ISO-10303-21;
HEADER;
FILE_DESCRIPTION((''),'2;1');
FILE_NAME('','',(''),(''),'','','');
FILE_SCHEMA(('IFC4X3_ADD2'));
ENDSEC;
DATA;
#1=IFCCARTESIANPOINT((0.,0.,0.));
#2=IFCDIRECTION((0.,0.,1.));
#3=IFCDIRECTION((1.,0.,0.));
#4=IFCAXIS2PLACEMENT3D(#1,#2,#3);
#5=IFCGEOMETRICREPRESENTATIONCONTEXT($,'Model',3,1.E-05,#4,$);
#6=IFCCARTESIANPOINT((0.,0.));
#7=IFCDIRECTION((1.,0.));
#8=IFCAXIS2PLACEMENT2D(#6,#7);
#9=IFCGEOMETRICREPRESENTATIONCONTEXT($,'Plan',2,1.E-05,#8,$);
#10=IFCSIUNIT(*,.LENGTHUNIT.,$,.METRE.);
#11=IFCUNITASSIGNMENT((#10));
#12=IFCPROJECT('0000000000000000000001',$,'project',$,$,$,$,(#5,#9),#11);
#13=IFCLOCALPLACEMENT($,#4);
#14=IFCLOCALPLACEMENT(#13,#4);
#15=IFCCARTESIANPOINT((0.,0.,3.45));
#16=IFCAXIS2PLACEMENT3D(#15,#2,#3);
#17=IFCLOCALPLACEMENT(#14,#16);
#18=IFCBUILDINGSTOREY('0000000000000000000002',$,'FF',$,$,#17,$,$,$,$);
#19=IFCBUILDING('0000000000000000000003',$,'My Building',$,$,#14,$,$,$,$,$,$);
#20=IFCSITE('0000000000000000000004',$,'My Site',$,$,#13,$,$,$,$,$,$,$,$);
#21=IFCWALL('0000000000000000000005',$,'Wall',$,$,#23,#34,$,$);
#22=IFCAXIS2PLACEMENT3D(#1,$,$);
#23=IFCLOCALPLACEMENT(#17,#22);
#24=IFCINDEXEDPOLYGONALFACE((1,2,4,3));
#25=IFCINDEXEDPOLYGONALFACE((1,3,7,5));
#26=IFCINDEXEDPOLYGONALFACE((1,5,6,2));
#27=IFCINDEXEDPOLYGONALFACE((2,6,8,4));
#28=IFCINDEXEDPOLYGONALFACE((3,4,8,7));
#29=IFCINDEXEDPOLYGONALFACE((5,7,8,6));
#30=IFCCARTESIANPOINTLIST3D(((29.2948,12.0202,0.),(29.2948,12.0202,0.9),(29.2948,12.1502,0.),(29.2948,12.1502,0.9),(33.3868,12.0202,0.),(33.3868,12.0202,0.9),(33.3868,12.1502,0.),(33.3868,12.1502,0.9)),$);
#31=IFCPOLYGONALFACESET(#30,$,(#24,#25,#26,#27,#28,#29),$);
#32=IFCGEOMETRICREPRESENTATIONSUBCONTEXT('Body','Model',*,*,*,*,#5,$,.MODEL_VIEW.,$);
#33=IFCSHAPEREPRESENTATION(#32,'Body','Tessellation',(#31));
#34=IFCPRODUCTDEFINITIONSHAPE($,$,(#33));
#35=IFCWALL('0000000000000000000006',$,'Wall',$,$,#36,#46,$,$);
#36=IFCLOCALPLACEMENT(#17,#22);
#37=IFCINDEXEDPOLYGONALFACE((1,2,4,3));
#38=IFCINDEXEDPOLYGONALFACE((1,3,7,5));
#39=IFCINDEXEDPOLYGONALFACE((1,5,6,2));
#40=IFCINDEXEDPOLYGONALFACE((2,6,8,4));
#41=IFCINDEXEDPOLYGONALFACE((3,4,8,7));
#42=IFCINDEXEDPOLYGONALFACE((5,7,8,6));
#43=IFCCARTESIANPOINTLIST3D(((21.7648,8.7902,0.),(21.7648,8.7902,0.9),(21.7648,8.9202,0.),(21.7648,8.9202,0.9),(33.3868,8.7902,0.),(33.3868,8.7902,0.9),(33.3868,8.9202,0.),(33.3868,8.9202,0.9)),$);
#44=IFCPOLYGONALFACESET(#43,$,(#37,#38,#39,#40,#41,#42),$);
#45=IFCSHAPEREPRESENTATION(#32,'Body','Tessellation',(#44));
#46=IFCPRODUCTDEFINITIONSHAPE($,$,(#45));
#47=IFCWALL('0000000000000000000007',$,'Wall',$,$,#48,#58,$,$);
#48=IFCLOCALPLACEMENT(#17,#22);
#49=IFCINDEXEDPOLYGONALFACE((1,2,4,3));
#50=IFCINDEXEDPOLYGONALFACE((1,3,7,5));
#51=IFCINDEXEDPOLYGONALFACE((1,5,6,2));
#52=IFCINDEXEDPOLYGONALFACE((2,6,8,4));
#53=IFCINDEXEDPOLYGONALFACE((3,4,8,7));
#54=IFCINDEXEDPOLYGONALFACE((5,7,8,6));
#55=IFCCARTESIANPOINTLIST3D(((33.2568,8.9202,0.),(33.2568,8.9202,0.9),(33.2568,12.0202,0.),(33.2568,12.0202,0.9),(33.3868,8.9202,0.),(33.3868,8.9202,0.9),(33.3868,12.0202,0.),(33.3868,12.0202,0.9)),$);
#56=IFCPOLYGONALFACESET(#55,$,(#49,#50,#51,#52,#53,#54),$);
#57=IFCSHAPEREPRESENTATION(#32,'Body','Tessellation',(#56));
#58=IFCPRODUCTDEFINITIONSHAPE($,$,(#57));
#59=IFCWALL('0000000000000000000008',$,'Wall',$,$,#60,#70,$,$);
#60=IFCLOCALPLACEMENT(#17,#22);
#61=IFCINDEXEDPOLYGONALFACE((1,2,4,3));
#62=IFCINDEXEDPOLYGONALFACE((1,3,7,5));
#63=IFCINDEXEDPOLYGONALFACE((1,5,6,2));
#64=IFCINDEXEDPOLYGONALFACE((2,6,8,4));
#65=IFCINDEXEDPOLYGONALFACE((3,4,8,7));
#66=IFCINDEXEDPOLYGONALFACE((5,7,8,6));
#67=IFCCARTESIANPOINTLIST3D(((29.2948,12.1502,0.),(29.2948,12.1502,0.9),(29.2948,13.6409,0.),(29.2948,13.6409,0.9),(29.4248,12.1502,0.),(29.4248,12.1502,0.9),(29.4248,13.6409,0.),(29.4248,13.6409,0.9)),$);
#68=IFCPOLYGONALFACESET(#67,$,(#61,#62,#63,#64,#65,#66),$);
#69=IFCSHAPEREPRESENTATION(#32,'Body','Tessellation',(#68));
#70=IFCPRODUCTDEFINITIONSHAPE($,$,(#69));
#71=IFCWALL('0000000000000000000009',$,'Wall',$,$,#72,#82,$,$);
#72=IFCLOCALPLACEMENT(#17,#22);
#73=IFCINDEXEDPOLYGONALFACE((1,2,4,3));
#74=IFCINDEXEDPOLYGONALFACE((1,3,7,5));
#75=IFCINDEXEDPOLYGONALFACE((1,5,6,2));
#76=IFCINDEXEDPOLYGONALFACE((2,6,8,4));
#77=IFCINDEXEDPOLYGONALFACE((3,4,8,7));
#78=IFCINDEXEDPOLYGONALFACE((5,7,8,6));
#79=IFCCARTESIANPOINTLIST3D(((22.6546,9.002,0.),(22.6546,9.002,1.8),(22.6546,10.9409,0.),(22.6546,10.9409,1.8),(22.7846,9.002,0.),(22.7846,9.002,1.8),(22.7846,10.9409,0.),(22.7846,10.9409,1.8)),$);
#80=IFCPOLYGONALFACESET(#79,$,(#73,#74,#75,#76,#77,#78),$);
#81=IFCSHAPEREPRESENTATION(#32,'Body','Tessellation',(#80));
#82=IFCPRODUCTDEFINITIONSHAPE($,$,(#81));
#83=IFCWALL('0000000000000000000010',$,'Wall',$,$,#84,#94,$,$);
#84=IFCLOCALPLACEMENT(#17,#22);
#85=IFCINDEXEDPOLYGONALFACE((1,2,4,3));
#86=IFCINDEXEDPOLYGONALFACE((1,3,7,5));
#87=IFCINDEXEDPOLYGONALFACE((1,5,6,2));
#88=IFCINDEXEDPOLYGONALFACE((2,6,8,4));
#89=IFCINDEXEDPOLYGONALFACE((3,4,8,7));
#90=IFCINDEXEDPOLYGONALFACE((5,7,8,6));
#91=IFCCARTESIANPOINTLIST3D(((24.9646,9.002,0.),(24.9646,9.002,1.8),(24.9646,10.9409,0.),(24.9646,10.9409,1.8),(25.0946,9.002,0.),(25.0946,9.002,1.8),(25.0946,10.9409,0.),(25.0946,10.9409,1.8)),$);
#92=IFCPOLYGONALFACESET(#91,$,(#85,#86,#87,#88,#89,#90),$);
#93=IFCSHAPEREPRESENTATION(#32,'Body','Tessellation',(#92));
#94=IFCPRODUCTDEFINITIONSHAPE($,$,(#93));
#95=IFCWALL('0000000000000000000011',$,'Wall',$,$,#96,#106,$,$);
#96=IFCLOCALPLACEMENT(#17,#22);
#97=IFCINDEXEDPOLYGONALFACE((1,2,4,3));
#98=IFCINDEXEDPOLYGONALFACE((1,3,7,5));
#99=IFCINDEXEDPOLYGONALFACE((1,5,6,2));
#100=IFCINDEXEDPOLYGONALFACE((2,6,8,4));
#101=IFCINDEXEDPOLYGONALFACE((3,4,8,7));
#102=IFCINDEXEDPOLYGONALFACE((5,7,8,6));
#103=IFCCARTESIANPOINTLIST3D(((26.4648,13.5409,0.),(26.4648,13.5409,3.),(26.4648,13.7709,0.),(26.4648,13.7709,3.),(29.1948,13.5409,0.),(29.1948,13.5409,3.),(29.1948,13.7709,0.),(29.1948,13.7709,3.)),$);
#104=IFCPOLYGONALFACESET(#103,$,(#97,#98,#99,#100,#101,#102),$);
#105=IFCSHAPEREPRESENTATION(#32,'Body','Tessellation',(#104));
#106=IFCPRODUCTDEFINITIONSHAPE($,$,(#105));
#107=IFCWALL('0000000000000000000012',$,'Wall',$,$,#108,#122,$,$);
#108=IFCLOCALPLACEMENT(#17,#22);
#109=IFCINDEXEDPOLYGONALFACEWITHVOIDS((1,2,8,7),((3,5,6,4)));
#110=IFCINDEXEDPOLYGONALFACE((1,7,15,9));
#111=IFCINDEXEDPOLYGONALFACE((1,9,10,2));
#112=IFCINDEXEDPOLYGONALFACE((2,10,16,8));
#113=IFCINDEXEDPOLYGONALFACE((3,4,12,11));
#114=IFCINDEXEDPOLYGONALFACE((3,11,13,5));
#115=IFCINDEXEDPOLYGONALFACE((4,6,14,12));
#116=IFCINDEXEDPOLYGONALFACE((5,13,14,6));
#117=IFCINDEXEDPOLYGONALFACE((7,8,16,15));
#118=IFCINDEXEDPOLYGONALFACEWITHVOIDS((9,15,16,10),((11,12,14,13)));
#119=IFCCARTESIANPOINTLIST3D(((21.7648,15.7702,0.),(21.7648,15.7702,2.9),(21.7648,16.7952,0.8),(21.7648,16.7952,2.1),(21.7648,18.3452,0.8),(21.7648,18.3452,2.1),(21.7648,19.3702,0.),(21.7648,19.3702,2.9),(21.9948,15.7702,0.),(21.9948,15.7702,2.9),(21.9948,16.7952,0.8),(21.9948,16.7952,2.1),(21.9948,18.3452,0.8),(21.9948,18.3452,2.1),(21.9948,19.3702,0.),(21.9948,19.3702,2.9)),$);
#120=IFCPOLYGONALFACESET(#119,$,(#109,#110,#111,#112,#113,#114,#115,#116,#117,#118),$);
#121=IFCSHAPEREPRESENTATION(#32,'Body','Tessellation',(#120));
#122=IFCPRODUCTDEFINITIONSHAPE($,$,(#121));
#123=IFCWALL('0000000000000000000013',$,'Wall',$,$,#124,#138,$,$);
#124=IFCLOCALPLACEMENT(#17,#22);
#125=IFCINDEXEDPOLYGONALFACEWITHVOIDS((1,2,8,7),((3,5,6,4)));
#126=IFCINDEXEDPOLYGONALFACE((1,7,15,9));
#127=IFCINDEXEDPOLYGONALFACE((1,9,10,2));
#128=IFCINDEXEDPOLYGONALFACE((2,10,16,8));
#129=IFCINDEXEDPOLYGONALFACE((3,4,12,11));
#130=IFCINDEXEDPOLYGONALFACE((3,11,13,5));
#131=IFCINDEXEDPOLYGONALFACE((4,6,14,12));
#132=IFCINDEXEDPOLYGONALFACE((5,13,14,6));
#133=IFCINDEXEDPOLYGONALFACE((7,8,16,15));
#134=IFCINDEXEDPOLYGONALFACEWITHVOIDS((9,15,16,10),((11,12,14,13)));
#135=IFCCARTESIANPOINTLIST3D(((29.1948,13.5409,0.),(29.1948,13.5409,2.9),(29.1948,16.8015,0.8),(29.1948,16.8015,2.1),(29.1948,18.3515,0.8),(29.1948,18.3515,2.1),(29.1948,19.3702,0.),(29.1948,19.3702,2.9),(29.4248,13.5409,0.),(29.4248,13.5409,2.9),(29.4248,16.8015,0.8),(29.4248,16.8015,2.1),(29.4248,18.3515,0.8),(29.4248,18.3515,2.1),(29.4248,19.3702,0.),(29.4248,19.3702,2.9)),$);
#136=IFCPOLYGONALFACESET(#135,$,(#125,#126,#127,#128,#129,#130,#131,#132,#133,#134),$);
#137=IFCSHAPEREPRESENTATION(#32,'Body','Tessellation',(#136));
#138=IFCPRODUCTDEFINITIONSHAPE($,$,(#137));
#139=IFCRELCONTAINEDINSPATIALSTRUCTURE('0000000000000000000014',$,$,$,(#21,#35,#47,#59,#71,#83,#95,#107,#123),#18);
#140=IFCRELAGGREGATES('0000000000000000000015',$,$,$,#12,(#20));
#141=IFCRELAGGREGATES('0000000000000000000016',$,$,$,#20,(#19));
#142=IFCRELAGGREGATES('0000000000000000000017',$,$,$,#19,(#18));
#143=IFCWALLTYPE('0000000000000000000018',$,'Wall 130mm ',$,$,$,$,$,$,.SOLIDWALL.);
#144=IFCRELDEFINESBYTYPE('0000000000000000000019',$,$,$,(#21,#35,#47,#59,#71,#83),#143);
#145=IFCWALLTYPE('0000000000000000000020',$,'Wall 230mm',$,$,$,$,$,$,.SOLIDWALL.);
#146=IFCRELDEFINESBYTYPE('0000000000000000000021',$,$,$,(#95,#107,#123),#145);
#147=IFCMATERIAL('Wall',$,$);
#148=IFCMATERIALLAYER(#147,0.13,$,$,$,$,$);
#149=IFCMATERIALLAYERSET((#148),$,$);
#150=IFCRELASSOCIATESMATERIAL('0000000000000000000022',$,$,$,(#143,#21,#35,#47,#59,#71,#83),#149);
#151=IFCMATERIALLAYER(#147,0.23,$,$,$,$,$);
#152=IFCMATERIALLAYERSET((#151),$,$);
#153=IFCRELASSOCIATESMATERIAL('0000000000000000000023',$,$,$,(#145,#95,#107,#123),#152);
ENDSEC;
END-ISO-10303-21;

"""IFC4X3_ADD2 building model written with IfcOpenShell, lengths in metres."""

from ifc_helpers import new_model, si_unit, frame, origin_with_axes, origin_2d_with_axis, place, context, subcontext, project, spatial, line, indexed_curve, outline, extrude, source, transform, mapped, material, layer, layer_set, layer_usage, type_object, element, save


model = new_model("IFC4X3_ADD2")

# Units and contexts
model_context = context("Model", 3, precision=1e-05, world=origin_with_axes())
plan_context = context("Plan", 2, precision=1e-05, world=origin_2d_with_axis())
body_context_1 = subcontext(model_context, "Body", "Model", "MODEL_VIEW")
ifc_project = project(units=[si_unit("LENGTHUNIT", "METRE")], contexts=[model_context, plan_context])

# Site, building, storey
site_placement = place(None, origin_with_axes())
site = spatial("IfcSite", under=ifc_project, at=site_placement, Name="My Site")
building_placement = place(site_placement, origin_with_axes())
building = spatial("IfcBuilding", under=site, at=building_placement, Name="My Building")
storey_placement = place(building_placement, frame((0.0, 0.0, 3.45), z_axis=(0.0, 0.0, 1.0), x_axis=(1.0, 0.0, 0.0)))
storey = spatial("IfcBuildingStorey", under=building, at=storey_placement, Name="FF")

# Walls
ifc_material_1 = material(Name="Wall")
ifc_layer_1 = layer(ifc_material_1, 0.13)
ifc_layer_set_1 = layer_set([ifc_layer_1])
ifc_layer_usage_1 = layer_usage(ifc_layer_set_1, "AXIS2", "POSITIVE", 0.0)
wall_type_1 = type_object("IfcWallType", Name="Wall 130mm ", PredefinedType="SOLIDWALL", material=ifc_layer_set_1)
wall_1_placement = place(storey_placement, frame((33.3868, 12.1502, 0.0), z_axis=(0.0, 0.0, 1.0), x_axis=(-1.0, 0.0, 0.0)))
element("IfcWall", 1, at=wall_1_placement, inside=storey, type_object=wall_type_1, material=ifc_layer_usage_1, Name="Wall", context=body_context_1, shape_type="SweptSolid", body=[
    extrude(outline(indexed_curve([(0.0, 0.0), (0.0, 0.13), (4.092, 0.13), (4.092, 0.0), (0.0, 0.0)], self_intersect=False)), origin_with_axes(), (0.0, 0.0, 1.0), 0.9),
])
ifc_layer_usage_2 = layer_usage(ifc_layer_set_1, "AXIS2", "POSITIVE", 0.0)
wall_2_placement = place(storey_placement, frame((33.3868, 8.9202, 0.0), z_axis=(0.0, 0.0, 1.0), x_axis=(-1.0, 0.0, 0.0)))
element("IfcWall", 2, at=wall_2_placement, inside=storey, type_object=wall_type_1, material=ifc_layer_usage_2, Name="Wall", context=body_context_1, shape_type="SweptSolid", body=[
    extrude(outline(indexed_curve([(0.0, 0.0), (0.0, 0.13), (11.622, 0.13), (11.622, 0.0), (0.0, 0.0)], self_intersect=False)), origin_with_axes(), (0.0, 0.0, 1.0), 0.9),
])
ifc_layer_usage_3 = layer_usage(ifc_layer_set_1, "AXIS2", "POSITIVE", 0.0)
wall_3_placement = place(storey_placement, frame((33.2568, 12.0202, 0.0), z_axis=(0.0, 0.0, 1.0), x_axis=(0.0, -1.0, 0.0)))
element("IfcWall", 3, at=wall_3_placement, inside=storey, type_object=wall_type_1, material=ifc_layer_usage_3, Name="Wall", context=body_context_1, shape_type="SweptSolid", body=[
    extrude(outline(indexed_curve([(0.0, 0.0), (0.0, 0.13), (3.1, 0.13), (3.1, 0.0), (0.0, 0.0)], self_intersect=False)), origin_with_axes(), (0.0, 0.0, 1.0), 0.9),
])
ifc_layer_usage_4 = layer_usage(ifc_layer_set_1, "AXIS2", "POSITIVE", 0.0)
wall_4_placement = place(storey_placement, frame((29.2948, 13.6409, 0.0), z_axis=(0.0, 0.0, 1.0), x_axis=(0.0, -1.0, 0.0)))
element("IfcWall", 4, at=wall_4_placement, inside=storey, type_object=wall_type_1, material=ifc_layer_usage_4, Name="Wall", context=body_context_1, shape_type="SweptSolid", body=[
    extrude(outline(indexed_curve([(0.0, 0.0), (0.0, 0.13), (1.4907, 0.13), (1.4907, 0.0), (0.0, 0.0)], self_intersect=False)), origin_with_axes(), (0.0, 0.0, 1.0), 0.9),
])
ifc_layer_usage_5 = layer_usage(ifc_layer_set_1, "AXIS2", "POSITIVE", 0.0)
wall_5_placement = place(storey_placement, frame((22.7846, 9.002, 0.0), z_axis=(0.0, 0.0, 1.0), x_axis=(0.0, 1.0, 0.0)))
element("IfcWall", 5, at=wall_5_placement, inside=storey, type_object=wall_type_1, material=ifc_layer_usage_5, Name="Wall", context=body_context_1, shape_type="SweptSolid", body=[
    extrude(outline(indexed_curve([(0.0, 0.0), (0.0, 0.13), (1.9389, 0.13), (1.9389, 0.0), (0.0, 0.0)], self_intersect=False)), origin_with_axes(), (0.0, 0.0, 1.0), 1.8),
])
ifc_layer_usage_6 = layer_usage(ifc_layer_set_1, "AXIS2", "POSITIVE", 0.0)
wall_6_placement = place(storey_placement, frame((25.0946, 9.002, 0.0), z_axis=(0.0, 0.0, 1.0), x_axis=(0.0, 1.0, 0.0)))
element("IfcWall", 6, at=wall_6_placement, inside=storey, type_object=wall_type_1, material=ifc_layer_usage_6, Name="Wall", context=body_context_1, shape_type="SweptSolid", body=[
    extrude(outline(indexed_curve([(0.0, 0.0), (0.0, 0.13), (1.9389, 0.13), (1.9389, 0.0), (0.0, 0.0)], self_intersect=False)), origin_with_axes(), (0.0, 0.0, 1.0), 1.8),
])
ifc_layer_2 = layer(ifc_material_1, 0.23)
ifc_layer_set_2 = layer_set([ifc_layer_2])
ifc_layer_usage_7 = layer_usage(ifc_layer_set_2, "AXIS2", "POSITIVE", 0.0)
wall_type_2 = type_object("IfcWallType", Name="Wall 230mm", PredefinedType="SOLIDWALL", material=ifc_layer_set_2)
wall_7_placement = place(storey_placement, frame((29.1948, 13.7709, 0.0), z_axis=(0.0, 0.0, 1.0), x_axis=(-1.0, 0.0, 0.0)))
element("IfcWall", 7, at=wall_7_placement, inside=storey, type_object=wall_type_2, material=ifc_layer_usage_7, Name="Wall", context=body_context_1, shape_type="SweptSolid", body=[
    extrude(outline(indexed_curve([(0.0, 0.0), (0.0, 0.23), (2.73, 0.23), (2.73, 0.0), (0.0, 0.0)], self_intersect=False)), origin_with_axes(), (0.0, 0.0, 1.0), 3.0),
])

# Walls, openings
ifc_layer_usage_8 = layer_usage(ifc_layer_set_2, "AXIS2", "POSITIVE", 0.0)
wall_8_placement = place(storey_placement, frame((21.9948, 15.7702, 0.0), z_axis=(0.0, 0.0, 1.0), x_axis=(0.000001, 1.0, 0.0)))
wall_8 = element("IfcWall", 8, at=wall_8_placement, inside=storey, type_object=wall_type_2, material=ifc_layer_usage_8, Name="Wall", context=body_context_1, shape_type="SweptSolid", body=[
    extrude(outline(indexed_curve([(0.0, 0.0), (0.0, 0.23), (3.6, 0.23), (3.6, 0.0), (0.0, 0.0)], self_intersect=False)), origin_with_axes(), (0.0, 0.0, 1.0), 2.9),
])
shared_shape_1 = source(origin_with_axes(), body_context_1, "Body", "SweptSolid", [
    extrude(outline(indexed_curve([(0.0, 0.0), (1.55, 0.0), (1.55, 1.3), (0.0, 1.3)], segments=[line(1, 2, 3, 4, 1)])), frame((-0.775, -0.6, 0.0), z_axis=(0.0, -1.0, 0.0), x_axis=(1.0, 0.0, 0.0)), (0.0, 0.0, -1.0), 1.2),
])
opening_1_placement = place(wall_8_placement, frame((1.8, 0.0, 0.8), z_axis=(0.0, 0.0, 1.0), x_axis=(1.0, 0.0, 0.0)))
element("IfcOpeningElement", 9, at=opening_1_placement, cuts=wall_8, PredefinedType="OPENING", context=body_context_1, shape_type="MappedRepresentation", body=[
    mapped(shared_shape_1, transform((0.0, 0.0, 0.0), x_axis=(1.0, 0.0, 0.0), y_axis=(0.0, 1.0, 0.0), z_axis=(0.0, 0.0, 1.0), scale=1.0)),
])
ifc_layer_usage_9 = layer_usage(ifc_layer_set_2, "AXIS2", "POSITIVE", 0.0)
wall_9_placement = place(storey_placement, frame((29.4248, 13.5409, 0.0), z_axis=(0.0, 0.0, 1.0), x_axis=(0.000001, 1.0, 0.0)))
wall_9 = element("IfcWall", 10, at=wall_9_placement, inside=storey, type_object=wall_type_2, material=ifc_layer_usage_9, Name="Wall", context=body_context_1, shape_type="SweptSolid", body=[
    extrude(outline(indexed_curve([(0.0, 0.0), (0.0, 0.23), (5.8293, 0.23), (5.8293, 0.0), (0.0, 0.0)], self_intersect=False)), origin_with_axes(), (0.0, 0.0, 1.0), 2.9),
])
opening_2_placement = place(wall_9_placement, frame((4.0356, 0.0, 0.8), z_axis=(0.0, 0.0, 1.0), x_axis=(1.0, 0.0, 0.0)))
element("IfcOpeningElement", 11, at=opening_2_placement, cuts=wall_9, PredefinedType="OPENING", context=body_context_1, shape_type="MappedRepresentation", body=[
    mapped(shared_shape_1, transform((0.0, 0.0, 0.0), x_axis=(1.0, 0.0, 0.0), y_axis=(0.0, 1.0, 0.0), z_axis=(0.0, 0.0, 1.0), scale=1.0)),
])

save(model, "model.ifc")
